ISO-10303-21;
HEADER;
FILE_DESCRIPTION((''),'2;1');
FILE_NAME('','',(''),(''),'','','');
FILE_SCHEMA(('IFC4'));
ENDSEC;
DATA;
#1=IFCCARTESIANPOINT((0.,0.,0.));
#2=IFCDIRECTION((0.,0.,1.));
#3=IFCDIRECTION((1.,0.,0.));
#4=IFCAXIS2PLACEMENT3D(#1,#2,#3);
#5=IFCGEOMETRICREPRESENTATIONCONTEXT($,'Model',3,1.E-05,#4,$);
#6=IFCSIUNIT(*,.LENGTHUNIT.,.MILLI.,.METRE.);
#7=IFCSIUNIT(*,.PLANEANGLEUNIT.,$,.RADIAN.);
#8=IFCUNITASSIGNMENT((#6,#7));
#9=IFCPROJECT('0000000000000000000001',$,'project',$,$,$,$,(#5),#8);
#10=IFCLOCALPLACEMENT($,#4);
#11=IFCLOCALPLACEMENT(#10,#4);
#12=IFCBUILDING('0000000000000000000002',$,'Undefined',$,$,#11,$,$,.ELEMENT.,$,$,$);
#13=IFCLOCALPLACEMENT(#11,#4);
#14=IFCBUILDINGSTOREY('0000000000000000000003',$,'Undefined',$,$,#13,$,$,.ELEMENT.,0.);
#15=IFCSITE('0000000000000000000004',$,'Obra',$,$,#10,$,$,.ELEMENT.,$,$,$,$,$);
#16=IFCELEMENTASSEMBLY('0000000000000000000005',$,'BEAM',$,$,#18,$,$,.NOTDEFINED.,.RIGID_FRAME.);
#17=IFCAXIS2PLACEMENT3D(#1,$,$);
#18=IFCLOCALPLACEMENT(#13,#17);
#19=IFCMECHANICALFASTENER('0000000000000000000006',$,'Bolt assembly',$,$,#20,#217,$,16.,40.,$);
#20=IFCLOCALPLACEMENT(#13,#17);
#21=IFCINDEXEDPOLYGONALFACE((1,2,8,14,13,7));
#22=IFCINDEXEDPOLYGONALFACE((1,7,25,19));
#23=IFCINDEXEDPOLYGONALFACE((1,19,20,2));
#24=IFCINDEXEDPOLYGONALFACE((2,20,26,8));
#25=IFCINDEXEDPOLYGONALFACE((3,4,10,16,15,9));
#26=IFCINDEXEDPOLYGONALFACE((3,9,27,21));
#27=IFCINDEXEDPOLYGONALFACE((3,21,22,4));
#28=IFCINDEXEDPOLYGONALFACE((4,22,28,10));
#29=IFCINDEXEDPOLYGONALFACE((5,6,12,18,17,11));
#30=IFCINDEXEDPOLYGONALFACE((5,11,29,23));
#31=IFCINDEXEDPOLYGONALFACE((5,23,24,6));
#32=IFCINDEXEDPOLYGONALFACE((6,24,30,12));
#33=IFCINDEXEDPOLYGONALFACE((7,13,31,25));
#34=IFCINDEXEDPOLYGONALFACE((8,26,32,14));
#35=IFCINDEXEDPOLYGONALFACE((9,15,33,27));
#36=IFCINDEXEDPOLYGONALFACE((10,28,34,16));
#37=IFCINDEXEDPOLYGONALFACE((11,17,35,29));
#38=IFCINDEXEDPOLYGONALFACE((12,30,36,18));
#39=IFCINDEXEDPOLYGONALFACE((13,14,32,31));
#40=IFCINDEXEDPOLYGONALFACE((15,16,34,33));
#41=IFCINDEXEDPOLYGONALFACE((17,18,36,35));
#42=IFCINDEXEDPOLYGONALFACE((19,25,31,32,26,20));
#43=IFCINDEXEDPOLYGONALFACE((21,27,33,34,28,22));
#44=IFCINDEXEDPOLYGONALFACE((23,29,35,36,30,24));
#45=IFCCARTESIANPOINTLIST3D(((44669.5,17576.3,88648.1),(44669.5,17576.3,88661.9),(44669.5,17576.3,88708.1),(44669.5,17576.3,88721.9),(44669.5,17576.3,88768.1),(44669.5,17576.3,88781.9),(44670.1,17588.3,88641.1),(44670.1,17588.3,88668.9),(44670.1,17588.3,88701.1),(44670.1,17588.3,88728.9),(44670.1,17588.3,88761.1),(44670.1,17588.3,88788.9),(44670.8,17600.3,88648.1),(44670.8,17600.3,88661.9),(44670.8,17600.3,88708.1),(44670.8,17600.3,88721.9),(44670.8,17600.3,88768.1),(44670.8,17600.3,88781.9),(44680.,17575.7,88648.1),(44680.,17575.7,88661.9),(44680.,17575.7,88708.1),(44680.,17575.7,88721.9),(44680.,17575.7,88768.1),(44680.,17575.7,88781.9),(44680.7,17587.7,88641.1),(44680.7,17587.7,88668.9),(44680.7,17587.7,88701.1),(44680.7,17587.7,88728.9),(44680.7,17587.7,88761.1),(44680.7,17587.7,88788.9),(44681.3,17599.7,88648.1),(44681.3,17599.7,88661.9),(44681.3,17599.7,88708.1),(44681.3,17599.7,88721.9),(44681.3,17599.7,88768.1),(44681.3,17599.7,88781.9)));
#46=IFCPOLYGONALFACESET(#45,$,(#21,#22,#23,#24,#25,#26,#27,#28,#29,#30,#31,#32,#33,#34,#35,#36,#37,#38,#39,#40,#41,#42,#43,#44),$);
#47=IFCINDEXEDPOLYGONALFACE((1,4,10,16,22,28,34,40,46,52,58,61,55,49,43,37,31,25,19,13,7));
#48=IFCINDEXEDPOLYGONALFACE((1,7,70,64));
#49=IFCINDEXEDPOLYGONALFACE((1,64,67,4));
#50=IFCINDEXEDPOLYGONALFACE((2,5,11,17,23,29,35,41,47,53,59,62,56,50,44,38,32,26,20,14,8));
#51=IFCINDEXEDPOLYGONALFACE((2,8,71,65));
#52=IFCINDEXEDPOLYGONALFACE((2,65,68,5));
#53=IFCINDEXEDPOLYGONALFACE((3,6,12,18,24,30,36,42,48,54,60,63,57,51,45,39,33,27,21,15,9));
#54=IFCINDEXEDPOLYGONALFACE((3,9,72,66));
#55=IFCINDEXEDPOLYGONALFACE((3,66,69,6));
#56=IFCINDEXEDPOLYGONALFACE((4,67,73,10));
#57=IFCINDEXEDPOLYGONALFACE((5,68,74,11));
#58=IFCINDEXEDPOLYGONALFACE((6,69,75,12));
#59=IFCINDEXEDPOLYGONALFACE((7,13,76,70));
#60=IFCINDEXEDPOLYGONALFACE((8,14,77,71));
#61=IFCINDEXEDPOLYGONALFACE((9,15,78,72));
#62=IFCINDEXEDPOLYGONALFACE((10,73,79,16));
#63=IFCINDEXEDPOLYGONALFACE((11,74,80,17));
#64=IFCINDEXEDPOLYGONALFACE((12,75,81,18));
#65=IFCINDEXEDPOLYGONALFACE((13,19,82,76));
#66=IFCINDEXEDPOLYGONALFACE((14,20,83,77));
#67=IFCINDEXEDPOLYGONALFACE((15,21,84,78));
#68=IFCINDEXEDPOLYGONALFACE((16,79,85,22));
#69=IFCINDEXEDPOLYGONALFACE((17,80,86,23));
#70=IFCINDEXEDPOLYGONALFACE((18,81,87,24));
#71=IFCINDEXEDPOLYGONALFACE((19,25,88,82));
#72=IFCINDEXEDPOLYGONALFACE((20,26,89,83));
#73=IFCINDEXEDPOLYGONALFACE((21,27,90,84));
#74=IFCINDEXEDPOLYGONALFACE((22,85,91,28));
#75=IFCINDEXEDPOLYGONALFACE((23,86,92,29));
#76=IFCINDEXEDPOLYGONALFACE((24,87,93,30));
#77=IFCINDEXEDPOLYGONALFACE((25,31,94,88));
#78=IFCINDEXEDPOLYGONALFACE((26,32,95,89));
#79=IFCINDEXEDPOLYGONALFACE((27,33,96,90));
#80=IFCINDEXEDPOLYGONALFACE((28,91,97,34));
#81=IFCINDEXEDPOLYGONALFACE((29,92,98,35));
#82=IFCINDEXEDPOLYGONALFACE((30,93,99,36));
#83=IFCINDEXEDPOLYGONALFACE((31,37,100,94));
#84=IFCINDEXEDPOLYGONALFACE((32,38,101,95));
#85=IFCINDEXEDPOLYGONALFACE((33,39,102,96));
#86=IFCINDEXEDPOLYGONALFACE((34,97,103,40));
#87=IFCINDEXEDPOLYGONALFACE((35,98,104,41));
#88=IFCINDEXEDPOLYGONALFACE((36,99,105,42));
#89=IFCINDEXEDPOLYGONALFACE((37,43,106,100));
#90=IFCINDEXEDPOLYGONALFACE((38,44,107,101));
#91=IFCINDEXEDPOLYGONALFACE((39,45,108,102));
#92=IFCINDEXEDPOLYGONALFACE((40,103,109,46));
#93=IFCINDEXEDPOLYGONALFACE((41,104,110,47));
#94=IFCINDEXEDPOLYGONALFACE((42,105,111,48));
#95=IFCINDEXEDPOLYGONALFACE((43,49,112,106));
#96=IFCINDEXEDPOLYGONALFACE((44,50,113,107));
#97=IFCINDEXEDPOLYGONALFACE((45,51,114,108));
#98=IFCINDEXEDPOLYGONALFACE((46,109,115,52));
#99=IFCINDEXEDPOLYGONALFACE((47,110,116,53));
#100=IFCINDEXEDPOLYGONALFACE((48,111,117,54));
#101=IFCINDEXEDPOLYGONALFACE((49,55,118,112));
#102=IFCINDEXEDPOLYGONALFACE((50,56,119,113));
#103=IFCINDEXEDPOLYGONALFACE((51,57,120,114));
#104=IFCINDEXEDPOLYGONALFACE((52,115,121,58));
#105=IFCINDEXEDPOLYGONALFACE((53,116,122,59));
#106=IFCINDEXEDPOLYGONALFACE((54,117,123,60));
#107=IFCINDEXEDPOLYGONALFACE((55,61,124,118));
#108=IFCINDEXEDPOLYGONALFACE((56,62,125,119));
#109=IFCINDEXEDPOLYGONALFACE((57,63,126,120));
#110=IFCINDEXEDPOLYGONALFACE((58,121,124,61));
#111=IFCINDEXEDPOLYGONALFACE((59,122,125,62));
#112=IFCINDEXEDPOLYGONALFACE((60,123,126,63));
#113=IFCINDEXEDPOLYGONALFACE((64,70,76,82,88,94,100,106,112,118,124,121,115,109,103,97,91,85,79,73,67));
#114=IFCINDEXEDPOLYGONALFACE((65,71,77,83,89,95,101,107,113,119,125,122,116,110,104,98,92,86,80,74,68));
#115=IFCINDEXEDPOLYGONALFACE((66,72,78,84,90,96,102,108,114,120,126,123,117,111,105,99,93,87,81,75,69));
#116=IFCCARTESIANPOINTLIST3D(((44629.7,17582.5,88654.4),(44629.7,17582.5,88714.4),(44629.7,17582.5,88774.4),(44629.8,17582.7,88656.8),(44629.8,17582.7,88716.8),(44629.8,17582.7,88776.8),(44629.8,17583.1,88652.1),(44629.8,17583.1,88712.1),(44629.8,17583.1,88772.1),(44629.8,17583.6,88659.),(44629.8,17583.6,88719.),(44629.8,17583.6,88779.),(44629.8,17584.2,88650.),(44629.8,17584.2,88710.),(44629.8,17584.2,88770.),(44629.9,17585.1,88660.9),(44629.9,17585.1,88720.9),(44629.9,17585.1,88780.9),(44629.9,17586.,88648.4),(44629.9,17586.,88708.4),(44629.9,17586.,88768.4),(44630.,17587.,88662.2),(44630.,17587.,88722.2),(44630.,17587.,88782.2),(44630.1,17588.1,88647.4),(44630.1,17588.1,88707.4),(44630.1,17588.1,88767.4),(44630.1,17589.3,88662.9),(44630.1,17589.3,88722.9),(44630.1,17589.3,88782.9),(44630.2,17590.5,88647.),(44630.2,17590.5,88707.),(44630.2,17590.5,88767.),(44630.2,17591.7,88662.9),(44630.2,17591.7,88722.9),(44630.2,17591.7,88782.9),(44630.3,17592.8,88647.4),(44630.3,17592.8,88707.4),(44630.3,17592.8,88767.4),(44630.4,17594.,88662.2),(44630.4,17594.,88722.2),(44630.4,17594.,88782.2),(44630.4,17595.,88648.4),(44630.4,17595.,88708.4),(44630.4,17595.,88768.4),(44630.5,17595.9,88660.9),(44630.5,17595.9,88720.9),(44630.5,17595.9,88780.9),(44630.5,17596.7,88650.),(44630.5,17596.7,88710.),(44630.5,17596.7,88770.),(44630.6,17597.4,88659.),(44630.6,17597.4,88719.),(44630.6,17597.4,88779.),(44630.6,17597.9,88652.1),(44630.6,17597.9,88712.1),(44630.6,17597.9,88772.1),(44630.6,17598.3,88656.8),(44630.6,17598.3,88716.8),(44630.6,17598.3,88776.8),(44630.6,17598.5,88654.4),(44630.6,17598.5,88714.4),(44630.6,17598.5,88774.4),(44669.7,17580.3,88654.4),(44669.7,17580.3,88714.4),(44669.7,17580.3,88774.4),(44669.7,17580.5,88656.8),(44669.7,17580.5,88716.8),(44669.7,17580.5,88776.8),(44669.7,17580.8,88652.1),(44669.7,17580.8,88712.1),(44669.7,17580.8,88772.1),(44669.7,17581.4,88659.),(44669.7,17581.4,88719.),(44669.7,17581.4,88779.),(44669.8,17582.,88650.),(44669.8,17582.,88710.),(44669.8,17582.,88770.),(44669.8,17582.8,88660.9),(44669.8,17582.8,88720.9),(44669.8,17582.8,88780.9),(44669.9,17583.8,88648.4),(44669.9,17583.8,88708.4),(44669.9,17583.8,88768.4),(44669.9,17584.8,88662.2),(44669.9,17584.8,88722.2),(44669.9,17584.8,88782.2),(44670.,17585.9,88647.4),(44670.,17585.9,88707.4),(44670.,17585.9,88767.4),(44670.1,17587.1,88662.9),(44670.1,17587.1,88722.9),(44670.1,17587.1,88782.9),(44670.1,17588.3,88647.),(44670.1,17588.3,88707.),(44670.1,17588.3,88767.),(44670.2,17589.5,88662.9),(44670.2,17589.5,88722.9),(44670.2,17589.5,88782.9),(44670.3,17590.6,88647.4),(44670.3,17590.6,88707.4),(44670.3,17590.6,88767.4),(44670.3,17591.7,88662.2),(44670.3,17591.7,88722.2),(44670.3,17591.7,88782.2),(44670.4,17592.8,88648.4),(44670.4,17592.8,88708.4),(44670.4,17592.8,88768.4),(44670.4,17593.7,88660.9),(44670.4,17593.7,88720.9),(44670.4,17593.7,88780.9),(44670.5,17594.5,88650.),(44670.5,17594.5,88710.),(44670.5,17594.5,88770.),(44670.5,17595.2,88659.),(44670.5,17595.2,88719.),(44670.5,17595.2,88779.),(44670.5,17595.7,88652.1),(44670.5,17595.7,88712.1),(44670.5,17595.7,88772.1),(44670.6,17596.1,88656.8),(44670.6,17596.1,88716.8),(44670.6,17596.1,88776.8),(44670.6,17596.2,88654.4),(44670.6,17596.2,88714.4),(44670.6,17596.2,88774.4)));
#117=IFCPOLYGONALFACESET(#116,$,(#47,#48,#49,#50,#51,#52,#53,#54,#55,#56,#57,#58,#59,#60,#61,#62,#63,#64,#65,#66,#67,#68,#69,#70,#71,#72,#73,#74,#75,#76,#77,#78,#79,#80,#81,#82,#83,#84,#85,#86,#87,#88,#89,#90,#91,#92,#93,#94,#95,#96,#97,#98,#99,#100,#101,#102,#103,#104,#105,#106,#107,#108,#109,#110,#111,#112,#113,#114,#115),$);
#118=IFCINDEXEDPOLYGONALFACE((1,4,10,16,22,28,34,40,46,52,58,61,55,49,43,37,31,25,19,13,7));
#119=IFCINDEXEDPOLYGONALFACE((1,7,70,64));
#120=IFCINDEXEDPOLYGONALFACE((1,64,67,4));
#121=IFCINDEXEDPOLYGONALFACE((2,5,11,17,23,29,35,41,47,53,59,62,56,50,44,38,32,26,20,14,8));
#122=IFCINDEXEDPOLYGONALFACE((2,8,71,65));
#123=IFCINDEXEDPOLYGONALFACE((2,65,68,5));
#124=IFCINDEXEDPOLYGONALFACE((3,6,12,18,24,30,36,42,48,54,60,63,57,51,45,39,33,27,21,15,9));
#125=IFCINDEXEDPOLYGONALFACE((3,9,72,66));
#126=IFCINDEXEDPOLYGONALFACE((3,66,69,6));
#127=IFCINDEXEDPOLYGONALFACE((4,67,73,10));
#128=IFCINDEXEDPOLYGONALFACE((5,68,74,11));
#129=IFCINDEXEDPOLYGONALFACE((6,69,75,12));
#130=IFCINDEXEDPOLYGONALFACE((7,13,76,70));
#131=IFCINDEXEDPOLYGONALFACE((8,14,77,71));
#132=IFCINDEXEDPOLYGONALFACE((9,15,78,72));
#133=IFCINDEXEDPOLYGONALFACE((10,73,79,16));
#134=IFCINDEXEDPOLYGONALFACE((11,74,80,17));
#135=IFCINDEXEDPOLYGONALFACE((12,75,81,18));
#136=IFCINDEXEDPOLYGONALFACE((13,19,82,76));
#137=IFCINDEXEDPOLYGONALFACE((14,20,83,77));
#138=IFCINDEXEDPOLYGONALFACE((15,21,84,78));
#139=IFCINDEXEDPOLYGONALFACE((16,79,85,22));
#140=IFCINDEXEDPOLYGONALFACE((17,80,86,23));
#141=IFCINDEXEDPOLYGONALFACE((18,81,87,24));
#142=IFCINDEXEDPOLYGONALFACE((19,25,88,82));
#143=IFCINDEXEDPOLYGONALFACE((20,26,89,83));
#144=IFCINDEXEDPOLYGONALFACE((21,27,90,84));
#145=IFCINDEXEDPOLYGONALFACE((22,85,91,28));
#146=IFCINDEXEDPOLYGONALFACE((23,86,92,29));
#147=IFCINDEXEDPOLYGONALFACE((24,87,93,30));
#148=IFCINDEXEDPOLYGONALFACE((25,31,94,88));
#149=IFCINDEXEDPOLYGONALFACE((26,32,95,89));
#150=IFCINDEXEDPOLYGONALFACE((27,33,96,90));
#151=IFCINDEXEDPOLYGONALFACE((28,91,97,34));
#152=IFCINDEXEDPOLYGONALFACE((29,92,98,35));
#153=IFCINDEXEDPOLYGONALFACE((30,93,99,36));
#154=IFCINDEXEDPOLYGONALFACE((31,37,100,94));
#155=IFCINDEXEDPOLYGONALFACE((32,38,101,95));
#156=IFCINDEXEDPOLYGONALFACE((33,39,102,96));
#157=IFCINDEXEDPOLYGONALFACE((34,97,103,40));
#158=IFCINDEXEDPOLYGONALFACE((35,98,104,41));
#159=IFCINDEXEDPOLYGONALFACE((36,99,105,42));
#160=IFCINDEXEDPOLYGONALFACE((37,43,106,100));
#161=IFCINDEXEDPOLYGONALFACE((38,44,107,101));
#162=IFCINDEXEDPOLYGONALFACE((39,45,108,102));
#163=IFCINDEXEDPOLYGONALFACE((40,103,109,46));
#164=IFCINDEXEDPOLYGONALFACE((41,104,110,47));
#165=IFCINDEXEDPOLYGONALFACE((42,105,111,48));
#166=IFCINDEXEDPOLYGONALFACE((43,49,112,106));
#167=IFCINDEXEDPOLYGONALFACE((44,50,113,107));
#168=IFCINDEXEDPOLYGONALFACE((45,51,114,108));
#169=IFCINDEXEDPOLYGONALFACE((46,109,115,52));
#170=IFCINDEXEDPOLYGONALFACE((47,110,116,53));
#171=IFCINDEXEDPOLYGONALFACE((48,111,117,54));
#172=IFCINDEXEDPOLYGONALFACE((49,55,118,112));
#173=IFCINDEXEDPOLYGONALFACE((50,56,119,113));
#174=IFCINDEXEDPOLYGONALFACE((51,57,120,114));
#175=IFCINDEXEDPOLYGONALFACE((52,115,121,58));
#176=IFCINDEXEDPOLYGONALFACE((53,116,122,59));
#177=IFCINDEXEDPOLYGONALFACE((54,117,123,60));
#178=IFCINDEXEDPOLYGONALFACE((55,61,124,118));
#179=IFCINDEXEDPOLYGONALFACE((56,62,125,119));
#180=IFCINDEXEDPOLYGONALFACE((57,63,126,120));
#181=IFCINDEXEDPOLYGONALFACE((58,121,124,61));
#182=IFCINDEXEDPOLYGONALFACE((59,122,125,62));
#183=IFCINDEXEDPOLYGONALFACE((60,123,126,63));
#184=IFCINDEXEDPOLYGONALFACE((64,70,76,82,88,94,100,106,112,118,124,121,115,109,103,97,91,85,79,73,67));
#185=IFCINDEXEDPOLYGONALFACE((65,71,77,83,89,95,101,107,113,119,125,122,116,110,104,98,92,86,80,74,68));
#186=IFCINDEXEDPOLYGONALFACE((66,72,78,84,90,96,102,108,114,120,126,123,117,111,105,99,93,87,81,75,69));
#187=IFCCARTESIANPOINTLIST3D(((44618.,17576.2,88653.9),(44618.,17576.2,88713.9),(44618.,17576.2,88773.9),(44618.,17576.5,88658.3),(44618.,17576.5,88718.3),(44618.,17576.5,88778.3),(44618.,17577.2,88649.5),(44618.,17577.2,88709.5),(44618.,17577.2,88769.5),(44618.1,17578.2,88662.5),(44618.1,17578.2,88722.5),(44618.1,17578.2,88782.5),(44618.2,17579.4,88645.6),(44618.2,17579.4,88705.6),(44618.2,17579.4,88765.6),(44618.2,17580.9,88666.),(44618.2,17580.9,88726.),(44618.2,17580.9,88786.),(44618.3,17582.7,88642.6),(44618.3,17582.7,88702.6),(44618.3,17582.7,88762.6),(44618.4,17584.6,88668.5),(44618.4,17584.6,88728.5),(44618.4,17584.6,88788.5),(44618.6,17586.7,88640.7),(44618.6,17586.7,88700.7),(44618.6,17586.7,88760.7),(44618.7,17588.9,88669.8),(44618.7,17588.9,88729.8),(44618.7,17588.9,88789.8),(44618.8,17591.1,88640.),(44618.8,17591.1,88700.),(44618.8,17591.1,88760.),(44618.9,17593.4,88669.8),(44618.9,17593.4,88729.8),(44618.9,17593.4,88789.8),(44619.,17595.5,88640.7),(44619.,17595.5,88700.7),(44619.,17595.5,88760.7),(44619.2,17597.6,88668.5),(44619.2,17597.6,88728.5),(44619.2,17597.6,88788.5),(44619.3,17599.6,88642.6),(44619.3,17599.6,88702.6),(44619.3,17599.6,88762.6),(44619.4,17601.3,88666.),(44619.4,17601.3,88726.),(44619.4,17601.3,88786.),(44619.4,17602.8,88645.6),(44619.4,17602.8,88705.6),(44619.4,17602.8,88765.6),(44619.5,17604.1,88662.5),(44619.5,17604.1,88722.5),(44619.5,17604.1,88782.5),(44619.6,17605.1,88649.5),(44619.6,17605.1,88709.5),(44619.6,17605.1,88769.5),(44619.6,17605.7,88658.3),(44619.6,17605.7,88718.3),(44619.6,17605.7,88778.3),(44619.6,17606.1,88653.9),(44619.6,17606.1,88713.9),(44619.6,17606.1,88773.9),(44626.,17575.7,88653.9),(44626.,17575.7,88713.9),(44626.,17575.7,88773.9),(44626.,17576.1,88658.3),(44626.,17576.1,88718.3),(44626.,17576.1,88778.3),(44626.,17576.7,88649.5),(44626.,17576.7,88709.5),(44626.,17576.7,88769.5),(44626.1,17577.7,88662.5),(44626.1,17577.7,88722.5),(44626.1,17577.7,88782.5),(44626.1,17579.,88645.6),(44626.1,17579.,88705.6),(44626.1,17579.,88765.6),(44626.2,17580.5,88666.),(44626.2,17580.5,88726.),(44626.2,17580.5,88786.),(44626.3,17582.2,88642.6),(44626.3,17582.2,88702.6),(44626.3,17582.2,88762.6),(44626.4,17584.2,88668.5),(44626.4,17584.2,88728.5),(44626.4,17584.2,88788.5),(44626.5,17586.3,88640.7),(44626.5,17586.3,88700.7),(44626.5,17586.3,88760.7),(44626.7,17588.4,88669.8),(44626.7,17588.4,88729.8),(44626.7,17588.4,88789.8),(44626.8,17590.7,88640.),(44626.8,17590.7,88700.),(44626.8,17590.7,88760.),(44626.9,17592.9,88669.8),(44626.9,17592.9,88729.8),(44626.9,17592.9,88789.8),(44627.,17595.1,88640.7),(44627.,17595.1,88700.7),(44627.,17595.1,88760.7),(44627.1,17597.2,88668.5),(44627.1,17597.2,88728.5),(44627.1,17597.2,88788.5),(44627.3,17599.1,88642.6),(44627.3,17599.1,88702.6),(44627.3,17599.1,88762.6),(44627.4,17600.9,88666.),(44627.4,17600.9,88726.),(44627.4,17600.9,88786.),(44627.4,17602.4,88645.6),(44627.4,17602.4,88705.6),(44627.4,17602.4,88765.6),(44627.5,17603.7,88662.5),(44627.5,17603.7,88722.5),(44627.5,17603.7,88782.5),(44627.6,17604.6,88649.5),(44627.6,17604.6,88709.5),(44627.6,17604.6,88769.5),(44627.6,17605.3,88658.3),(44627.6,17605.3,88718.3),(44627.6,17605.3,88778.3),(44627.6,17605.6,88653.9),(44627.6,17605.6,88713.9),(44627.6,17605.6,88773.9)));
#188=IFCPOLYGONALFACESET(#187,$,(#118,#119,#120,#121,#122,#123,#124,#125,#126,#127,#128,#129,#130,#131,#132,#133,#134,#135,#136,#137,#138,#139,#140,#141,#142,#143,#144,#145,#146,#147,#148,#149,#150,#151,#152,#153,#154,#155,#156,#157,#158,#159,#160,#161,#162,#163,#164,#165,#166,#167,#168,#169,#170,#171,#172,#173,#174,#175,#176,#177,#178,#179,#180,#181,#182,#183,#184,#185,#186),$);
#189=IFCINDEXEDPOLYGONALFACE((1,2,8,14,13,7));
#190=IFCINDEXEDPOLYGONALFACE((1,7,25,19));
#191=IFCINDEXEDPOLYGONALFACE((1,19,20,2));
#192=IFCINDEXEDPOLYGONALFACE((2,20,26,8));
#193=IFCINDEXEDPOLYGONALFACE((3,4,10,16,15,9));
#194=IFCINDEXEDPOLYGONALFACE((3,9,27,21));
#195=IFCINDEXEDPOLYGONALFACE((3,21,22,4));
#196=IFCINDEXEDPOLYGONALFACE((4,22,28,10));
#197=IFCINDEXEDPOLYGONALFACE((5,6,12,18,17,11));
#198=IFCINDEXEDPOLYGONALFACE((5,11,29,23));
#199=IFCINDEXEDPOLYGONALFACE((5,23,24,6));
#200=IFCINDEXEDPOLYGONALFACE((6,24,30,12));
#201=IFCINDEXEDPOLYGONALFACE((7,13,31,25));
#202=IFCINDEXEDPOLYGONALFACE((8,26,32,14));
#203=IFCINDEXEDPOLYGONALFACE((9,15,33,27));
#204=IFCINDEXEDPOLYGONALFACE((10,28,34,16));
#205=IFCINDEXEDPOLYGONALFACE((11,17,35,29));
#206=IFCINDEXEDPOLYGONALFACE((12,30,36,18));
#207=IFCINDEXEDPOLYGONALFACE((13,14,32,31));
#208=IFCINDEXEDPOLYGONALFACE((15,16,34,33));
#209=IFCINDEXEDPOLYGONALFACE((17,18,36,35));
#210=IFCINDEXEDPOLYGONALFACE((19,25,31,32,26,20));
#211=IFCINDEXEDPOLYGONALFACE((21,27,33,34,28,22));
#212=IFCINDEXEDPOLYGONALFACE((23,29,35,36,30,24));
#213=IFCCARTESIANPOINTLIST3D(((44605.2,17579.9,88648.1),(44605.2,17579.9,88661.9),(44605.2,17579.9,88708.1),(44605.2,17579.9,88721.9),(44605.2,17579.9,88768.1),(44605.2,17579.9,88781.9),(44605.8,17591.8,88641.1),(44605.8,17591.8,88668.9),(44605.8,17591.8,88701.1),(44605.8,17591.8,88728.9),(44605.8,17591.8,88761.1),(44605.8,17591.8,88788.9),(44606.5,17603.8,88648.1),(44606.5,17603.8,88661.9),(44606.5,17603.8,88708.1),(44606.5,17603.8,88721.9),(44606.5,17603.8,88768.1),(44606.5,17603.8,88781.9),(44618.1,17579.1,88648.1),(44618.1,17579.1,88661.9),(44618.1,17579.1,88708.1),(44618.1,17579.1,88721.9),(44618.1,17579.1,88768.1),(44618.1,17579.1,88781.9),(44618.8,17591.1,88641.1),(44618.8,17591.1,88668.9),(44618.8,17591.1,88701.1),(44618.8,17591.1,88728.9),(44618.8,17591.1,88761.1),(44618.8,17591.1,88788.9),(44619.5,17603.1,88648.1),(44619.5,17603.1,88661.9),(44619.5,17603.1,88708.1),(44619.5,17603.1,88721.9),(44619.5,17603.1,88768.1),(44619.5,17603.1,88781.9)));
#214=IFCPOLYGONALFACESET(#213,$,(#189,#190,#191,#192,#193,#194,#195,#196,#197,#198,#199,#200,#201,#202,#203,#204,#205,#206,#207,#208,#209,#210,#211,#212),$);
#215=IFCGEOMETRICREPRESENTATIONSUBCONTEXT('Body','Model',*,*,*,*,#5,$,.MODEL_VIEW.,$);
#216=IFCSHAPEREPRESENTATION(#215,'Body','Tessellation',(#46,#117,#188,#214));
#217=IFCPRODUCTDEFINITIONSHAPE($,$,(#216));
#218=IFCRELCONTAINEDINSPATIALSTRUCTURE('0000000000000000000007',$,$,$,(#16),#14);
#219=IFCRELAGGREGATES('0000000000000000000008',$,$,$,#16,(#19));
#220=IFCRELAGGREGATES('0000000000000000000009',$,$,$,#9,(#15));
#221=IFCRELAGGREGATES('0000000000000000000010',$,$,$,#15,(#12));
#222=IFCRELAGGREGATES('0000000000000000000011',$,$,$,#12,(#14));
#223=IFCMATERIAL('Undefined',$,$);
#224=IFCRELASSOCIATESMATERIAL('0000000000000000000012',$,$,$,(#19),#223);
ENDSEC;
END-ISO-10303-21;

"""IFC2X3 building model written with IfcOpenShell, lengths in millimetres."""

from ifc_helpers import new_model, si_unit, frame, origin_with_axes, origin_2d_with_axis, place, context, subcontext, project, spatial, polyline, circle, outline, extrude, source, transform, mapped, material, element, aggregate, save


model = new_model("IFC2X3")

# Units and contexts
model_context = context("Model", 3, precision=1e-05, world=origin_with_axes())
body_context = subcontext(model_context, "Body", "Model", "MODEL_VIEW")
ifc_project = project(units=[si_unit("LENGTHUNIT", "METRE", prefix="MILLI"), si_unit("PLANEANGLEUNIT", "RADIAN")], contexts=[model_context])

# Site, building, storey
site_placement = place(None, origin_with_axes())
site = spatial("IfcSite", under=ifc_project, at=site_placement, Name="Obra", CompositionType="ELEMENT")
building_placement = place(site_placement, origin_with_axes())
building = spatial("IfcBuilding", under=site, at=building_placement, Name="Undefined", CompositionType="ELEMENT")
storey_placement = place(building_placement, origin_with_axes())
storey = spatial("IfcBuildingStorey", under=building, at=storey_placement, Name="Undefined", CompositionType="ELEMENT", Elevation=0.0)

# Element assembly, mechanical fastener
ifc_material_1 = material(Name="Undefined")
shared_shape_1 = source(origin_with_axes(), body_context, "Body", "SweptSolid", [
    extrude(outline(polyline([(13.9, 0.0), (6.9, 12.0), (-6.9, 12.0), (-13.9, 0.0), (-6.9, -12.0), (6.9, -12.0), (13.9, 0.0)])), frame((0.0, -19.7, 0.0), z_axis=(0.0, 1.0, 0.0), x_axis=(1.0, 0.0, 0.0)), (0.0, 0.0, 1.0), 10.6),
    extrude(circle(Radius=8.0, at=origin_2d_with_axis()), frame((0.0, -9.1, 0.0), z_axis=(0.0, 1.0, 0.0), x_axis=(1.0, 0.0, 0.0)), (0.0, 0.0, 1.0), 40.0),
    extrude(circle(Radius=15.0, at=origin_2d_with_axis()), frame((0.0, 34.3, 0.0), z_axis=(0.0, 1.0, 0.0), x_axis=(1.0, 0.0, 0.0)), (0.0, 0.0, 1.0), 8.0),
    extrude(outline(polyline([(13.9, 0.0), (6.9, 12.0), (-6.9, 12.0), (-13.9, 0.0), (-6.9, -12.0), (6.9, -12.0), (13.9, 0.0)])), frame((0.0, 42.3, 0.0), z_axis=(0.0, 1.0, 0.0), x_axis=(1.0, 0.0, 0.0)), (0.0, 0.0, 1.0), 13.0),
])
assembly_1_placement = place(storey_placement, origin_with_axes())
assembly_1 = element("IfcElementAssembly", 1, at=assembly_1_placement, inside=storey, Name="BEAM", AssemblyPlace="NOTDEFINED", PredefinedType="RIGID_FRAME")
mechanical_fastener_1_placement = place(assembly_1_placement, frame((44658.3, 17538.9, 88835.0), z_axis=(0.055268, 0.998472, 0.0), x_axis=(0.0, 0.0, -1.0)))
mechanical_fastener_1 = element("IfcMechanicalFastener", 2, at=mechanical_fastener_1_placement, material=ifc_material_1, Name="Bolt assembly", NominalDiameter=16.0, NominalLength=40.0, context=body_context, shape_type="MappedRepresentation", body=[
    mapped(shared_shape_1, transform((60.0, 0.0, 50.0))),
    mapped(shared_shape_1, transform((120.0, 0.0, 50.0))),
    mapped(shared_shape_1, transform((180.0, 0.0, 50.0))),
])

aggregate(assembly_1, [mechanical_fastener_1])

save(model, "model.ifc")
